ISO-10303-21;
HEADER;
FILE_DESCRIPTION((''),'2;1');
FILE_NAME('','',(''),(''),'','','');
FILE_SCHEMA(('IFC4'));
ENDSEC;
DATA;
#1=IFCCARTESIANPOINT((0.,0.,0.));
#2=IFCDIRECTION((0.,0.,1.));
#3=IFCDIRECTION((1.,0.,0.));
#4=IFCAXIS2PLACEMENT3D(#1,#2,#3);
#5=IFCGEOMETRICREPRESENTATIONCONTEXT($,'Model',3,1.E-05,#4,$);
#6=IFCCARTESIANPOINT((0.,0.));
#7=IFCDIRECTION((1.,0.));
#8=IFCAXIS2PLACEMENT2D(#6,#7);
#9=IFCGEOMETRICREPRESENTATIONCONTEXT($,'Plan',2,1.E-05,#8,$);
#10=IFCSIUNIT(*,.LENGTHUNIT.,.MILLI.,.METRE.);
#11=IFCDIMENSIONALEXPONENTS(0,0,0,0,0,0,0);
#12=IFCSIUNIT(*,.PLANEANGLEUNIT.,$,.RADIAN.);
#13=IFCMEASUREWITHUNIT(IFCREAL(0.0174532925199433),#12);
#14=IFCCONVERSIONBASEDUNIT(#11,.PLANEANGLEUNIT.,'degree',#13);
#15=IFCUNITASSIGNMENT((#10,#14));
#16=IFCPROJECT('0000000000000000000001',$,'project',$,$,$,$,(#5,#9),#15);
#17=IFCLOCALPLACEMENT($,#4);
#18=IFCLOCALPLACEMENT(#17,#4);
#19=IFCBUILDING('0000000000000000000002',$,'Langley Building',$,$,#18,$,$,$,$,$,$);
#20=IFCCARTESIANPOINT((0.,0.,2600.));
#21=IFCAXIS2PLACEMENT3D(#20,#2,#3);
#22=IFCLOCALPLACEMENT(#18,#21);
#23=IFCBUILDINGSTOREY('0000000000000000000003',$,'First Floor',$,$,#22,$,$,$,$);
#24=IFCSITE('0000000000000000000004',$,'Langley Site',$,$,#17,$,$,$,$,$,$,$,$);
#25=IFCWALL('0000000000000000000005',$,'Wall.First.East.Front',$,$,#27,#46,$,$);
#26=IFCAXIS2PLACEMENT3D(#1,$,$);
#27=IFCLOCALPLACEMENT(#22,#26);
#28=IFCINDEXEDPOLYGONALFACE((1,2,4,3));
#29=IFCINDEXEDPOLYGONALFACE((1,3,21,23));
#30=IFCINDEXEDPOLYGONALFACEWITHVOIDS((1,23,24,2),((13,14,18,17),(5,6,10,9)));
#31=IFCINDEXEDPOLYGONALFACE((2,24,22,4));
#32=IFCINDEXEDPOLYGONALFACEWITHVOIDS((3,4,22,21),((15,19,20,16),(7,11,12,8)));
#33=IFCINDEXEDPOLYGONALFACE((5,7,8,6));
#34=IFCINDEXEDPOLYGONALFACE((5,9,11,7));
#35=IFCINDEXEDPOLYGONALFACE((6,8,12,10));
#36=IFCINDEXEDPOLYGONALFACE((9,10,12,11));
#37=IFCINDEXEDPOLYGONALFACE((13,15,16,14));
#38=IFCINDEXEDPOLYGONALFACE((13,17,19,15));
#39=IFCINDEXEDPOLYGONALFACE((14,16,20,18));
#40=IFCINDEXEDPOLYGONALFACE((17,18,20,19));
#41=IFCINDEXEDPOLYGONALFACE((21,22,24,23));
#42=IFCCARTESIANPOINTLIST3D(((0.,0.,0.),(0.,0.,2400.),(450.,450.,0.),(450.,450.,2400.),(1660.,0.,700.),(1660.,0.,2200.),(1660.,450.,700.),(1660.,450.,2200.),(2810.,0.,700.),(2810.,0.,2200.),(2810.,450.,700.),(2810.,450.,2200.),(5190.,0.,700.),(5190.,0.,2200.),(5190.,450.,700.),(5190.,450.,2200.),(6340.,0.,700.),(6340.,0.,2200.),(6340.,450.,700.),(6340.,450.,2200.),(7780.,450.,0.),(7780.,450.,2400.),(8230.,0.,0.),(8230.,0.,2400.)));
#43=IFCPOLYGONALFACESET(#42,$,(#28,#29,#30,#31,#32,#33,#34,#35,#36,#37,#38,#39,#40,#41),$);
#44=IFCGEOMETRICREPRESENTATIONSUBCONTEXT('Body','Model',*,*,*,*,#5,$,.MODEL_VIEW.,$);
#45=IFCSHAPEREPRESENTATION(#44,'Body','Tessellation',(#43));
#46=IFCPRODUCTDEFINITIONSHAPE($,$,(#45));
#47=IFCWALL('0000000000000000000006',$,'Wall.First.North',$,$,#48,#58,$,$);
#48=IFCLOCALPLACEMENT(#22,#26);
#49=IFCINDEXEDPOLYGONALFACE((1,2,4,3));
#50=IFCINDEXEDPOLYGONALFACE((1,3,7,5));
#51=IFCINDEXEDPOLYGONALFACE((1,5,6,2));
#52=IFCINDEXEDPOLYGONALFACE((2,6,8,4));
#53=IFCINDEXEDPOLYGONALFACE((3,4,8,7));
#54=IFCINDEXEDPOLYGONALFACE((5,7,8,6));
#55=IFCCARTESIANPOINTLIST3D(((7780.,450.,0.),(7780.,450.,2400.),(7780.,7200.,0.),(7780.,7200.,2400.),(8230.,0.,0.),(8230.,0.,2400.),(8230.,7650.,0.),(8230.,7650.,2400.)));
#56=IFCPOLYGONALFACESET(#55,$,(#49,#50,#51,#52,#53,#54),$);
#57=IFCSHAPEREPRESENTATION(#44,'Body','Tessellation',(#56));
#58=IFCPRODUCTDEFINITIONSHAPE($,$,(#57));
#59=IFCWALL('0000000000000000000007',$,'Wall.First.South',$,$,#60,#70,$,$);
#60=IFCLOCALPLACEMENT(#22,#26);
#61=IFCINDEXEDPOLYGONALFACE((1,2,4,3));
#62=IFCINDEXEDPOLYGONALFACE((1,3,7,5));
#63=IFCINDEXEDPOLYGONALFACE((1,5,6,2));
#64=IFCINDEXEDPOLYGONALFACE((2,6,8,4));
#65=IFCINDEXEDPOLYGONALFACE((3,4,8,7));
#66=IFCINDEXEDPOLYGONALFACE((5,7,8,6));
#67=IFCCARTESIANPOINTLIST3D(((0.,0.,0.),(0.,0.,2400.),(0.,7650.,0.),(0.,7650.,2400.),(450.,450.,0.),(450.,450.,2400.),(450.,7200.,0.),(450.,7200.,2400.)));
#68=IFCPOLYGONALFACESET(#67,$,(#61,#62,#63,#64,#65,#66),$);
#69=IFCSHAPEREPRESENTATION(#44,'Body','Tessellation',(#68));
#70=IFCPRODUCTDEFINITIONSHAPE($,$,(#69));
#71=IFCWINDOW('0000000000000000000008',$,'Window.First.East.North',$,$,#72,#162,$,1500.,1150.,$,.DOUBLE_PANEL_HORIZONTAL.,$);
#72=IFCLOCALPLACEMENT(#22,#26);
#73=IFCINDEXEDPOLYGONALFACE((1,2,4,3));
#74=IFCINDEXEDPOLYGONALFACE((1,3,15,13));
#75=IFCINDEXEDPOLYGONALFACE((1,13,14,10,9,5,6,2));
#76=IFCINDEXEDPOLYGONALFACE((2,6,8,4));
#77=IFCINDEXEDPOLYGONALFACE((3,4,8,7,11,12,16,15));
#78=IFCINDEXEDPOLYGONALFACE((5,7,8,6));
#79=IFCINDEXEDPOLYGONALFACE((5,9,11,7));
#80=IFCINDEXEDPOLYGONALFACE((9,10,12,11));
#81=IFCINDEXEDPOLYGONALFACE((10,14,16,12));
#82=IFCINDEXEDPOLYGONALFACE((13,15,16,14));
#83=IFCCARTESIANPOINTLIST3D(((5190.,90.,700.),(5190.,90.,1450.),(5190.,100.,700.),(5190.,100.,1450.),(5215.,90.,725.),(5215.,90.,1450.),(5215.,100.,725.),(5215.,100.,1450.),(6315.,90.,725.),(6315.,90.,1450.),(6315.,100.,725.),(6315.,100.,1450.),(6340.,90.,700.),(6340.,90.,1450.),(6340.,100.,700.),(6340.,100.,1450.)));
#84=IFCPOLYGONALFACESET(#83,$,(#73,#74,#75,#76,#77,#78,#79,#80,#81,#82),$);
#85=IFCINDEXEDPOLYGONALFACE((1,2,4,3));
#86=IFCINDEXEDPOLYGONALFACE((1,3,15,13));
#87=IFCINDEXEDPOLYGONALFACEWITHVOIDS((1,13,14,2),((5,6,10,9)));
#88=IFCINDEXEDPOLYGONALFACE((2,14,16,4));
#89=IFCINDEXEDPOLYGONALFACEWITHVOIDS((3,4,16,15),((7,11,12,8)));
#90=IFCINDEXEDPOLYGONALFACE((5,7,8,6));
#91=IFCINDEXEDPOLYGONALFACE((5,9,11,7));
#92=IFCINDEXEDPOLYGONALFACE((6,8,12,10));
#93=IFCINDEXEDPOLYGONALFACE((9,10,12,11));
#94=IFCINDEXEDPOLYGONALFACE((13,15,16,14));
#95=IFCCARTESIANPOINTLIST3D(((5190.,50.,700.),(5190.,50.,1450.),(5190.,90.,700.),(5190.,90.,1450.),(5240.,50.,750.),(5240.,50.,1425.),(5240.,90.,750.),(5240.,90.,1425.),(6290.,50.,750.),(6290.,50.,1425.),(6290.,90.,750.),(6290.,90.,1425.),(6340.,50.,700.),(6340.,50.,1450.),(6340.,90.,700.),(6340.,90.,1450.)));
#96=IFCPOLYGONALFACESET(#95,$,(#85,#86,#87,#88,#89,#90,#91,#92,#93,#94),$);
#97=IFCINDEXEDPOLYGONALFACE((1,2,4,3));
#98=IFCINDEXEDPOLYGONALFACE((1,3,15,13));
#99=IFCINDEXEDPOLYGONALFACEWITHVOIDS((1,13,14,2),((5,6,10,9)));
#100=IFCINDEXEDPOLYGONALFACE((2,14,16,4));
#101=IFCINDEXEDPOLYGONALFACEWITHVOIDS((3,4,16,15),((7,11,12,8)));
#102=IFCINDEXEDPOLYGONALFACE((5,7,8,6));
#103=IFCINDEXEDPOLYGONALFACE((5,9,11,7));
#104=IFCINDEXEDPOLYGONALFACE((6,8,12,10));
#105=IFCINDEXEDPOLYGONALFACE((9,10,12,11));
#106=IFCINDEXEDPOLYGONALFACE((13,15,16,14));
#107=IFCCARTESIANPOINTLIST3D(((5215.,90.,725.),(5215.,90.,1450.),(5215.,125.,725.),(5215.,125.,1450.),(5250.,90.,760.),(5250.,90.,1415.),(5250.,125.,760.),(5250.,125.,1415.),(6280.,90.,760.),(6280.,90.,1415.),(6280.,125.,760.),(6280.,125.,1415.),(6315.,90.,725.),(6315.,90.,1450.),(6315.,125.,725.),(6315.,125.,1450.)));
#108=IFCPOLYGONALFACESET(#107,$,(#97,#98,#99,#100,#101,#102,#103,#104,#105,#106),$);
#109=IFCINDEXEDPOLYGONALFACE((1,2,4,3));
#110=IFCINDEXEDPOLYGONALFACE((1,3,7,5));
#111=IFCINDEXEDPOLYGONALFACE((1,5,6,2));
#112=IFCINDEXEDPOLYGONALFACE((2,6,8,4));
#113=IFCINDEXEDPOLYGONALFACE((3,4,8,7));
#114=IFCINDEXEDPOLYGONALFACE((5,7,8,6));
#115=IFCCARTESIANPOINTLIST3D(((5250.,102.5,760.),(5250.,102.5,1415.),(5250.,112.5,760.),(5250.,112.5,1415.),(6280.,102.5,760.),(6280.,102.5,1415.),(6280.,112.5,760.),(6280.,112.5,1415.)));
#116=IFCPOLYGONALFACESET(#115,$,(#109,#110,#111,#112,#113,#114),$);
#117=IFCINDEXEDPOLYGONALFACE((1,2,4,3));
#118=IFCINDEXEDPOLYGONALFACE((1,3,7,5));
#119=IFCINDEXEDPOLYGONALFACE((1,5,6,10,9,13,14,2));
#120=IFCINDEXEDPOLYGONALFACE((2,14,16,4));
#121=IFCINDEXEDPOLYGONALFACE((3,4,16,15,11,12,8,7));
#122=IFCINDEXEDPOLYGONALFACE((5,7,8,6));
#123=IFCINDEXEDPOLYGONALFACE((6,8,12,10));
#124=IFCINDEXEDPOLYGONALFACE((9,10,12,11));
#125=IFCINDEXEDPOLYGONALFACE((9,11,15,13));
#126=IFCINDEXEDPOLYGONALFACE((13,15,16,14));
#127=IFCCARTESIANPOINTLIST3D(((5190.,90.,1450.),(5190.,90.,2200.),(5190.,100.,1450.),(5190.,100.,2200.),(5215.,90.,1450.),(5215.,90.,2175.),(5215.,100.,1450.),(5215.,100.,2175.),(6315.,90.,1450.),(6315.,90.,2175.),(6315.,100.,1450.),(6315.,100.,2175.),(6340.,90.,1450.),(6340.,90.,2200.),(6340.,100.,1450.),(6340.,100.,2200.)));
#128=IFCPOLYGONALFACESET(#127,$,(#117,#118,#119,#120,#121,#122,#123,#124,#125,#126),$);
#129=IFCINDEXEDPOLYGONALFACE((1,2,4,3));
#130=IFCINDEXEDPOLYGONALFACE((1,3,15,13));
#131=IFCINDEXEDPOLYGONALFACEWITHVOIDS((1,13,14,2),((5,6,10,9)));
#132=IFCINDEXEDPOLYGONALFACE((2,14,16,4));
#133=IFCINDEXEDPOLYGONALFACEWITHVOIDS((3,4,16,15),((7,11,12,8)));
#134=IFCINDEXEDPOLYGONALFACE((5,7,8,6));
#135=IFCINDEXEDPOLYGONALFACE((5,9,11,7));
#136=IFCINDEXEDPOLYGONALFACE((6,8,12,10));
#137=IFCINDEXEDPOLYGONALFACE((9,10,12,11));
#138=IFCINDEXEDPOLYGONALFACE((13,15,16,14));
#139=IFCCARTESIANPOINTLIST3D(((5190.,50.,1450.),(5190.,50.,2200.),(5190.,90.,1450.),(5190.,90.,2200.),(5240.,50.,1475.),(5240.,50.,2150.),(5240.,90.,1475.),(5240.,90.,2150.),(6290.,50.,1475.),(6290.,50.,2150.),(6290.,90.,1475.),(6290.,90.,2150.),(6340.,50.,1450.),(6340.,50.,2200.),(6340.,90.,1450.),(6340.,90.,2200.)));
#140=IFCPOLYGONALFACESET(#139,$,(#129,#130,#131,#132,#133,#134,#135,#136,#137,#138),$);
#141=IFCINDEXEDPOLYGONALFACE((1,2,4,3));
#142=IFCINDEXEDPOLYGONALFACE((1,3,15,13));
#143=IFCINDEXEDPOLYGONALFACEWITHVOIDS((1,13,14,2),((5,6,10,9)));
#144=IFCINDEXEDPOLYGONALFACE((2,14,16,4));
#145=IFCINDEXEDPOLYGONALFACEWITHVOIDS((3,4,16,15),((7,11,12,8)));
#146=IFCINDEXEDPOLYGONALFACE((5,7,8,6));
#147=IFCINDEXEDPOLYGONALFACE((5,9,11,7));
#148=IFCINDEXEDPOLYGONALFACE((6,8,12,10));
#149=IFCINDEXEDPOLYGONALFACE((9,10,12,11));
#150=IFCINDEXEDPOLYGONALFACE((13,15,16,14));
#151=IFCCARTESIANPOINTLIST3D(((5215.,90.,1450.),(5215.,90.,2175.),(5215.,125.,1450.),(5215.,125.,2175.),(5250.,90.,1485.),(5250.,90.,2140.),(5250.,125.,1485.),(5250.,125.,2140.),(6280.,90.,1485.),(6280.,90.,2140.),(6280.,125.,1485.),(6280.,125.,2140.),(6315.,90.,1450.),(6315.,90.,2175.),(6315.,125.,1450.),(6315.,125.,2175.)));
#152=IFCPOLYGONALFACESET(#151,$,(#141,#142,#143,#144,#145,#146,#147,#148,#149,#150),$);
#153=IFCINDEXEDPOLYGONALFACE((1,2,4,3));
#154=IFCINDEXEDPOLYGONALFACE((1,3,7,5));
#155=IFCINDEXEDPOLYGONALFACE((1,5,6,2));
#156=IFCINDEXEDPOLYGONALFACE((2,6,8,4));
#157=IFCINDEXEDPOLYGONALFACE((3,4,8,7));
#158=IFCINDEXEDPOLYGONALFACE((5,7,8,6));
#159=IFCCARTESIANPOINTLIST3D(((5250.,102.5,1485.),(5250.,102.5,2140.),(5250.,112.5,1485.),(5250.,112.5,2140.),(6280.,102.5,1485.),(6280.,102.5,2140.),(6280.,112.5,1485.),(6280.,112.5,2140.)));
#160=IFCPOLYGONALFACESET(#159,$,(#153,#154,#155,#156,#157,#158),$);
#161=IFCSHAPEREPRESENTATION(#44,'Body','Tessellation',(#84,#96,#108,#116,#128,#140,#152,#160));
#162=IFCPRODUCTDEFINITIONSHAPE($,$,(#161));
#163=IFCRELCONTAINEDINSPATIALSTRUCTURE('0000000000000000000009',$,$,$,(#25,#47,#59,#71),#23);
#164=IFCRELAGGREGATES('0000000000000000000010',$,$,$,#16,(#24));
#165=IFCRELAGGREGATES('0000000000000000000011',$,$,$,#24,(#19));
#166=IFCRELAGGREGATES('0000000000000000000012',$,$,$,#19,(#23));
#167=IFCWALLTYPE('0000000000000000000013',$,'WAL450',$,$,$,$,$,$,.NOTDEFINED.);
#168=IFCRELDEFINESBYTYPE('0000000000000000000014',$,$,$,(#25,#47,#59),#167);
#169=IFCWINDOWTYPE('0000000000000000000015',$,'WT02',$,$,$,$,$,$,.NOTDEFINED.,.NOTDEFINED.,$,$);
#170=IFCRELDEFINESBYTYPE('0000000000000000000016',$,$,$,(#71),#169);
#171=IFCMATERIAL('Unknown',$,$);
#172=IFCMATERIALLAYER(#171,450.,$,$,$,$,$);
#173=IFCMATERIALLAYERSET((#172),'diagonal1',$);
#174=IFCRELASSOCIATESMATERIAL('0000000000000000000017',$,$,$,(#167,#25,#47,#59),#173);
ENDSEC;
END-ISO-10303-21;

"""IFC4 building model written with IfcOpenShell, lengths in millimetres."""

from ifc_helpers import new_model, entity, si_unit, converted_unit, frame, origin_with_axes, origin_2d_with_axis, place, context, subcontext, project, spatial, line, indexed_curve, outline, extrude, shape, source, transform, mapped, material, layer, layer_set, layer_usage, type_object, type_shapes, element, save


model = new_model("IFC4")

# Units and contexts
model_context = context("Model", 3, precision=1e-05, world=origin_with_axes())
plan_context = context("Plan", 2, precision=1e-05, world=origin_2d_with_axis())
body_context_1 = subcontext(model_context, "Body", "Model", "MODEL_VIEW")
body_context_2 = subcontext(plan_context, "Body", "Plan", "PLAN_VIEW")
ifc_project = project(units=[si_unit("LENGTHUNIT", "METRE", prefix="MILLI"), converted_unit("PLANEANGLEUNIT", "degree", entity("IfcReal", 0.0174532925199433), si_unit("PLANEANGLEUNIT", "RADIAN"), dimensions=[0, 0, 0, 0, 0, 0, 0])], contexts=[model_context, plan_context])

# Site, building, storey
site_placement = place(None, origin_with_axes())
site = spatial("IfcSite", under=ifc_project, at=site_placement, Name="Langley Site")
building_placement = place(site_placement, origin_with_axes())
building = spatial("IfcBuilding", under=site, at=building_placement, Name="Langley Building")
storey_placement = place(building_placement, frame((0.0, 0.0, 2600.0), z_axis=(0.0, 0.0, 1.0), x_axis=(1.0, 0.0, 0.0)))
storey = spatial("IfcBuildingStorey", under=building, at=storey_placement, Name="First Floor")

# Shared definitions
ifc_material = material(Name="Unknown")

# Wall, openings
ifc_layer_1 = layer(ifc_material, 450.0)
ifc_layer_set_1 = layer_set([ifc_layer_1], Name="diagonal1")
ifc_layer_usage_1 = layer_usage(ifc_layer_set_1, "AXIS2", "POSITIVE", 0.0)
wall_type_1 = type_object("IfcWallType", Name="WAL450", PredefinedType="NOTDEFINED", material=ifc_layer_set_1)
wall_1_placement = place(storey_placement, frame((0.0, 0.0, 0.0), z_axis=(0.0, 0.0, 1.0), x_axis=(1.0, 0.0, 0.0)))
wall_1 = element("IfcWall", 1, at=wall_1_placement, inside=storey, type_object=wall_type_1, material=ifc_layer_usage_1, Name="Wall.First.East.Front", context=body_context_1, shape_type="SweptSolid", body=[
    extrude(outline(indexed_curve([(0.0, 0.0), (450.0, 450.0), (7780.0, 450.0), (8230.0, 0.0)], segments=[line(1, 2, 3, 4, 1)])), origin_with_axes(), (0.0, 0.0, 1.0), 2400.0),
])
shared_shape_1 = source(origin_with_axes(), body_context_1, "Body", "SweptSolid", [
    extrude(outline(indexed_curve([(0.0, 0.0), (1150.0, 0.0), (1150.0, 1500.0), (0.0, 1500.0)], segments=[line(1, 2, 3, 4, 1)])), frame((0.0, -600.0, 0.0), z_axis=(0.0, -1.0, 0.0), x_axis=(1.0, 0.0, 0.0)), (0.0, 0.0, -1.0), 1200.0),
])
opening_1_placement = place(wall_1_placement, frame((5190.0, 0.0, 700.0), z_axis=(0.0, 0.0, 1.0), x_axis=(1.0, 0.0, 0.0)))
element("IfcOpeningElement", 2, at=opening_1_placement, cuts=wall_1, PredefinedType="OPENING", context=body_context_1, shape_type="MappedRepresentation", body=[
    mapped(shared_shape_1, transform((0.0, 0.0, 0.0), x_axis=(1.0, 0.0, 0.0), y_axis=(0.0, 1.0, 0.0), z_axis=(0.0, 0.0, 1.0), scale=1.0)),
])
shared_shape_2 = source(origin_with_axes(), body_context_1, "Body", "SweptSolid", [
    extrude(outline(indexed_curve([(0.0, 0.0), (1150.0, 0.0), (1150.0, 1500.0), (0.0, 1500.0)], segments=[line(1, 2, 3, 4, 1)])), frame((0.0, -600.0, 0.0), z_axis=(0.0, -1.0, 0.0), x_axis=(1.0, 0.0, 0.0)), (0.0, 0.0, -1.0), 1200.0),
])
opening_2_placement = place(wall_1_placement, frame((1660.0, 0.0, 700.0), z_axis=(0.0, 0.0, 1.0), x_axis=(1.0, 0.0, 0.0)))
element("IfcOpeningElement", 3, at=opening_2_placement, cuts=wall_1, PredefinedType="OPENING", context=body_context_1, shape_type="MappedRepresentation", body=[
    mapped(shared_shape_2, transform((0.0, 0.0, 0.0), x_axis=(1.0, 0.0, 0.0), y_axis=(0.0, 1.0, 0.0), z_axis=(0.0, 0.0, 1.0), scale=1.0)),
])

# Wall
ifc_layer_usage_2 = layer_usage(ifc_layer_set_1, "AXIS2", "POSITIVE", 0.0)
wall_2_placement = place(storey_placement, frame((8230.0, 0.0, 0.0), z_axis=(0.0, 0.0, 1.0), x_axis=(0.0, 1.0, 0.0)))
element("IfcWall", 4, at=wall_2_placement, inside=storey, type_object=wall_type_1, material=ifc_layer_usage_2, Name="Wall.First.North", context=body_context_1, shape_type="SweptSolid", body=[
    extrude(outline(indexed_curve([(0.0, 0.0), (450.0, 450.0), (7200.0, 450.0), (7650.0, 0.0)], segments=[line(1, 2, 3, 4, 1)])), origin_with_axes(), (0.0, 0.0, 1.0), 2400.0),
])

# Wall
ifc_layer_usage_3 = layer_usage(ifc_layer_set_1, "AXIS2", "POSITIVE", 0.0)
wall_3_placement = place(storey_placement, frame((0.0, 7650.0, 0.0), z_axis=(0.0, 0.0, 1.0), x_axis=(0.0, -1.0, 0.0)))
element("IfcWall", 5, at=wall_3_placement, inside=storey, type_object=wall_type_1, material=ifc_layer_usage_3, Name="Wall.First.South", context=body_context_1, shape_type="SweptSolid", body=[
    extrude(outline(indexed_curve([(0.0, 0.0), (450.0, 450.0), (7200.0, 450.0), (7650.0, 0.0)], segments=[line(1, 2, 3, 4, 1)])), origin_with_axes(), (0.0, 0.0, 1.0), 2400.0),
])

# Window
window_type_1 = type_object("IfcWindowType", Name="WT02", PartitioningType="NOTDEFINED", PredefinedType="NOTDEFINED")
shared_shape_3 = source(origin_with_axes(), body_context_1, "Body", "SweptSolid", [
    extrude(outline(indexed_curve([(1150.0, 750.0), (1150.0, 0.0), (0.0, 0.0), (0.0, 750.0), (25.0, 750.0), (25.0, 25.0), (1125.0, 25.0), (1125.0, 750.0)], segments=[line(1, 2, 3, 4, 5, 6, 7, 8, 1)])), frame((0.0, 90.0, 0.0), z_axis=(0.0, -1.0, 0.0), x_axis=(1.0, 0.0, 0.0)), (0.0, 0.0, -1.0), 10.0),
    extrude(outline(indexed_curve([(0.0, 0.0), (1150.0, 0.0), (1150.0, 750.0), (0.0, 750.0)], segments=[line(1, 2, 3, 4, 1)]), holes=[indexed_curve([(50.0, 50.0), (1100.0, 50.0), (1100.0, 725.0), (50.0, 725.0)], segments=[line(1, 2, 3, 4, 1)])]), frame((0.0, 50.0, 0.0), z_axis=(0.0, -1.0, 0.0), x_axis=(1.0, 0.0, 0.0)), (0.0, 0.0, -1.0), 40.0),
    extrude(outline(indexed_curve([(0.0, 0.0), (1100.0, 0.0), (1100.0, 725.0), (0.0, 725.0)], segments=[line(1, 2, 3, 4, 1)]), holes=[indexed_curve([(35.0, 35.0), (1065.0, 35.0), (1065.0, 690.0), (35.0, 690.0)], segments=[line(1, 2, 3, 4, 1)])]), frame((25.0, 90.0, 25.0), z_axis=(0.0, -1.0, 0.0), x_axis=(1.0, 0.0, 0.0)), (0.0, 0.0, -1.0), 35.0),
    extrude(outline(indexed_curve([(35.0, 35.0), (1065.0, 35.0), (1065.0, 690.0), (35.0, 690.0)], segments=[line(1, 2, 3, 4, 1)])), frame((25.0, 102.5, 25.0), z_axis=(0.0, -1.0, 0.0), x_axis=(1.0, 0.0, 0.0)), (0.0, 0.0, -1.0), 10.0),
    extrude(outline(indexed_curve([(0.0, 0.0), (0.0, 750.0), (1150.0, 750.0), (1150.0, 0.0), (1125.0, 0.0), (1125.0, 725.0), (25.0, 725.0), (25.0, 0.0)], segments=[line(1, 2, 3, 4, 5, 6, 7, 8, 1)])), frame((0.0, 90.0, 750.0), z_axis=(0.0, -1.0, 0.0), x_axis=(1.0, 0.0, 0.0)), (0.0, 0.0, -1.0), 10.0),
    extrude(outline(indexed_curve([(0.0, 0.0), (1150.0, 0.0), (1150.0, 750.0), (0.0, 750.0)], segments=[line(1, 2, 3, 4, 1)]), holes=[indexed_curve([(50.0, 25.0), (1100.0, 25.0), (1100.0, 700.0), (50.0, 700.0)], segments=[line(1, 2, 3, 4, 1)])]), frame((0.0, 50.0, 750.0), z_axis=(0.0, -1.0, 0.0), x_axis=(1.0, 0.0, 0.0)), (0.0, 0.0, -1.0), 40.0),
    extrude(outline(indexed_curve([(0.0, 0.0), (1100.0, 0.0), (1100.0, 725.0), (0.0, 725.0)], segments=[line(1, 2, 3, 4, 1)]), holes=[indexed_curve([(35.0, 35.0), (1065.0, 35.0), (1065.0, 690.0), (35.0, 690.0)], segments=[line(1, 2, 3, 4, 1)])]), frame((25.0, 90.0, 750.0), z_axis=(0.0, -1.0, 0.0), x_axis=(1.0, 0.0, 0.0)), (0.0, 0.0, -1.0), 35.0),
    extrude(outline(indexed_curve([(35.0, 35.0), (1065.0, 35.0), (1065.0, 690.0), (35.0, 690.0)], segments=[line(1, 2, 3, 4, 1)])), frame((25.0, 102.5, 750.0), z_axis=(0.0, -1.0, 0.0), x_axis=(1.0, 0.0, 0.0)), (0.0, 0.0, -1.0), 10.0),
])
shared_shape_4 = source(origin_with_axes(), body_context_2, "Body", "Curve2D", [
    entity("IfcIndexedPolyCurve", entity("IfcCartesianPointList2D", [[50.0, 50.0], [1100.0, 50.0]])),
    entity("IfcIndexedPolyCurve", entity("IfcCartesianPointList2D", [[0.0, 100.0], [25.0, 100.0], [25.0, 90.0], [50.0, 90.0], [50.0, 50.0], [0.0, 50.0]]), [entity("IfcLineIndex", [1, 2, 3, 4, 5, 6, 1])]),
    entity("IfcIndexedPolyCurve", entity("IfcCartesianPointList2D", [[1150.0, 100.0], [1125.0, 100.0], [1125.0, 90.0], [1100.0, 90.0], [1100.0, 50.0], [1150.0, 50.0]]), [entity("IfcLineIndex", [1, 2, 3, 4, 5, 6, 1])]),
    entity("IfcIndexedPolyCurve", entity("IfcCartesianPointList2D", [[25.0, 90.0], [60.0, 90.0], [60.0, 125.0], [25.0, 125.0]]), [entity("IfcLineIndex", [1, 2, 3, 4, 1])]),
    entity("IfcIndexedPolyCurve", entity("IfcCartesianPointList2D", [[1125.0, 90.0], [1090.0, 90.0], [1090.0, 125.0], [1125.0, 125.0]]), [entity("IfcLineIndex", [1, 2, 3, 4, 1])]),
    entity("IfcIndexedPolyCurve", entity("IfcCartesianPointList2D", [[60.0, 90.0], [1090.0, 90.0]])),
    entity("IfcIndexedPolyCurve", entity("IfcCartesianPointList2D", [[60.0, 125.0], [1090.0, 125.0]])),
    entity("IfcIndexedPolyCurve", entity("IfcCartesianPointList2D", [[60.0, 107.5], [1090.0, 107.5]])),
])
type_shapes(window_type_1, [shared_shape_3, shared_shape_4])
for number, where, z_axis, x_axis, name in (
    (6, (5190.0, 0.0, 700.0), (0.0, 0.0, 1.0), (1.0, 0.0, 0.0), "Window.First.East.North"),
):
    element("IfcWindow", number, at=place(storey_placement, frame(where, z_axis=z_axis, x_axis=x_axis)), inside=storey, type_object=window_type_1, Name=name, OverallHeight=1500.0, OverallWidth=1150.0, PartitioningType="DOUBLE_PANEL_HORIZONTAL", shapes=[
        shape(body_context_1, "Body", "MappedRepresentation", [mapped(shared_shape_3, transform((0.0, 0.0, 0.0), x_axis=(1.0, 0.0, 0.0), y_axis=(0.0, 1.0, 0.0), z_axis=(0.0, 0.0, 1.0), scale=1.0))]),
        shape(body_context_2, "Body", "MappedRepresentation", [mapped(shared_shape_4, transform((0.0, 0.0, 0.0), x_axis=(1.0, 0.0, 0.0), y_axis=(0.0, 1.0, 0.0), z_axis=(0.0, 0.0, 1.0), scale=1.0))]),
    ])

save(model, "model.ifc")
